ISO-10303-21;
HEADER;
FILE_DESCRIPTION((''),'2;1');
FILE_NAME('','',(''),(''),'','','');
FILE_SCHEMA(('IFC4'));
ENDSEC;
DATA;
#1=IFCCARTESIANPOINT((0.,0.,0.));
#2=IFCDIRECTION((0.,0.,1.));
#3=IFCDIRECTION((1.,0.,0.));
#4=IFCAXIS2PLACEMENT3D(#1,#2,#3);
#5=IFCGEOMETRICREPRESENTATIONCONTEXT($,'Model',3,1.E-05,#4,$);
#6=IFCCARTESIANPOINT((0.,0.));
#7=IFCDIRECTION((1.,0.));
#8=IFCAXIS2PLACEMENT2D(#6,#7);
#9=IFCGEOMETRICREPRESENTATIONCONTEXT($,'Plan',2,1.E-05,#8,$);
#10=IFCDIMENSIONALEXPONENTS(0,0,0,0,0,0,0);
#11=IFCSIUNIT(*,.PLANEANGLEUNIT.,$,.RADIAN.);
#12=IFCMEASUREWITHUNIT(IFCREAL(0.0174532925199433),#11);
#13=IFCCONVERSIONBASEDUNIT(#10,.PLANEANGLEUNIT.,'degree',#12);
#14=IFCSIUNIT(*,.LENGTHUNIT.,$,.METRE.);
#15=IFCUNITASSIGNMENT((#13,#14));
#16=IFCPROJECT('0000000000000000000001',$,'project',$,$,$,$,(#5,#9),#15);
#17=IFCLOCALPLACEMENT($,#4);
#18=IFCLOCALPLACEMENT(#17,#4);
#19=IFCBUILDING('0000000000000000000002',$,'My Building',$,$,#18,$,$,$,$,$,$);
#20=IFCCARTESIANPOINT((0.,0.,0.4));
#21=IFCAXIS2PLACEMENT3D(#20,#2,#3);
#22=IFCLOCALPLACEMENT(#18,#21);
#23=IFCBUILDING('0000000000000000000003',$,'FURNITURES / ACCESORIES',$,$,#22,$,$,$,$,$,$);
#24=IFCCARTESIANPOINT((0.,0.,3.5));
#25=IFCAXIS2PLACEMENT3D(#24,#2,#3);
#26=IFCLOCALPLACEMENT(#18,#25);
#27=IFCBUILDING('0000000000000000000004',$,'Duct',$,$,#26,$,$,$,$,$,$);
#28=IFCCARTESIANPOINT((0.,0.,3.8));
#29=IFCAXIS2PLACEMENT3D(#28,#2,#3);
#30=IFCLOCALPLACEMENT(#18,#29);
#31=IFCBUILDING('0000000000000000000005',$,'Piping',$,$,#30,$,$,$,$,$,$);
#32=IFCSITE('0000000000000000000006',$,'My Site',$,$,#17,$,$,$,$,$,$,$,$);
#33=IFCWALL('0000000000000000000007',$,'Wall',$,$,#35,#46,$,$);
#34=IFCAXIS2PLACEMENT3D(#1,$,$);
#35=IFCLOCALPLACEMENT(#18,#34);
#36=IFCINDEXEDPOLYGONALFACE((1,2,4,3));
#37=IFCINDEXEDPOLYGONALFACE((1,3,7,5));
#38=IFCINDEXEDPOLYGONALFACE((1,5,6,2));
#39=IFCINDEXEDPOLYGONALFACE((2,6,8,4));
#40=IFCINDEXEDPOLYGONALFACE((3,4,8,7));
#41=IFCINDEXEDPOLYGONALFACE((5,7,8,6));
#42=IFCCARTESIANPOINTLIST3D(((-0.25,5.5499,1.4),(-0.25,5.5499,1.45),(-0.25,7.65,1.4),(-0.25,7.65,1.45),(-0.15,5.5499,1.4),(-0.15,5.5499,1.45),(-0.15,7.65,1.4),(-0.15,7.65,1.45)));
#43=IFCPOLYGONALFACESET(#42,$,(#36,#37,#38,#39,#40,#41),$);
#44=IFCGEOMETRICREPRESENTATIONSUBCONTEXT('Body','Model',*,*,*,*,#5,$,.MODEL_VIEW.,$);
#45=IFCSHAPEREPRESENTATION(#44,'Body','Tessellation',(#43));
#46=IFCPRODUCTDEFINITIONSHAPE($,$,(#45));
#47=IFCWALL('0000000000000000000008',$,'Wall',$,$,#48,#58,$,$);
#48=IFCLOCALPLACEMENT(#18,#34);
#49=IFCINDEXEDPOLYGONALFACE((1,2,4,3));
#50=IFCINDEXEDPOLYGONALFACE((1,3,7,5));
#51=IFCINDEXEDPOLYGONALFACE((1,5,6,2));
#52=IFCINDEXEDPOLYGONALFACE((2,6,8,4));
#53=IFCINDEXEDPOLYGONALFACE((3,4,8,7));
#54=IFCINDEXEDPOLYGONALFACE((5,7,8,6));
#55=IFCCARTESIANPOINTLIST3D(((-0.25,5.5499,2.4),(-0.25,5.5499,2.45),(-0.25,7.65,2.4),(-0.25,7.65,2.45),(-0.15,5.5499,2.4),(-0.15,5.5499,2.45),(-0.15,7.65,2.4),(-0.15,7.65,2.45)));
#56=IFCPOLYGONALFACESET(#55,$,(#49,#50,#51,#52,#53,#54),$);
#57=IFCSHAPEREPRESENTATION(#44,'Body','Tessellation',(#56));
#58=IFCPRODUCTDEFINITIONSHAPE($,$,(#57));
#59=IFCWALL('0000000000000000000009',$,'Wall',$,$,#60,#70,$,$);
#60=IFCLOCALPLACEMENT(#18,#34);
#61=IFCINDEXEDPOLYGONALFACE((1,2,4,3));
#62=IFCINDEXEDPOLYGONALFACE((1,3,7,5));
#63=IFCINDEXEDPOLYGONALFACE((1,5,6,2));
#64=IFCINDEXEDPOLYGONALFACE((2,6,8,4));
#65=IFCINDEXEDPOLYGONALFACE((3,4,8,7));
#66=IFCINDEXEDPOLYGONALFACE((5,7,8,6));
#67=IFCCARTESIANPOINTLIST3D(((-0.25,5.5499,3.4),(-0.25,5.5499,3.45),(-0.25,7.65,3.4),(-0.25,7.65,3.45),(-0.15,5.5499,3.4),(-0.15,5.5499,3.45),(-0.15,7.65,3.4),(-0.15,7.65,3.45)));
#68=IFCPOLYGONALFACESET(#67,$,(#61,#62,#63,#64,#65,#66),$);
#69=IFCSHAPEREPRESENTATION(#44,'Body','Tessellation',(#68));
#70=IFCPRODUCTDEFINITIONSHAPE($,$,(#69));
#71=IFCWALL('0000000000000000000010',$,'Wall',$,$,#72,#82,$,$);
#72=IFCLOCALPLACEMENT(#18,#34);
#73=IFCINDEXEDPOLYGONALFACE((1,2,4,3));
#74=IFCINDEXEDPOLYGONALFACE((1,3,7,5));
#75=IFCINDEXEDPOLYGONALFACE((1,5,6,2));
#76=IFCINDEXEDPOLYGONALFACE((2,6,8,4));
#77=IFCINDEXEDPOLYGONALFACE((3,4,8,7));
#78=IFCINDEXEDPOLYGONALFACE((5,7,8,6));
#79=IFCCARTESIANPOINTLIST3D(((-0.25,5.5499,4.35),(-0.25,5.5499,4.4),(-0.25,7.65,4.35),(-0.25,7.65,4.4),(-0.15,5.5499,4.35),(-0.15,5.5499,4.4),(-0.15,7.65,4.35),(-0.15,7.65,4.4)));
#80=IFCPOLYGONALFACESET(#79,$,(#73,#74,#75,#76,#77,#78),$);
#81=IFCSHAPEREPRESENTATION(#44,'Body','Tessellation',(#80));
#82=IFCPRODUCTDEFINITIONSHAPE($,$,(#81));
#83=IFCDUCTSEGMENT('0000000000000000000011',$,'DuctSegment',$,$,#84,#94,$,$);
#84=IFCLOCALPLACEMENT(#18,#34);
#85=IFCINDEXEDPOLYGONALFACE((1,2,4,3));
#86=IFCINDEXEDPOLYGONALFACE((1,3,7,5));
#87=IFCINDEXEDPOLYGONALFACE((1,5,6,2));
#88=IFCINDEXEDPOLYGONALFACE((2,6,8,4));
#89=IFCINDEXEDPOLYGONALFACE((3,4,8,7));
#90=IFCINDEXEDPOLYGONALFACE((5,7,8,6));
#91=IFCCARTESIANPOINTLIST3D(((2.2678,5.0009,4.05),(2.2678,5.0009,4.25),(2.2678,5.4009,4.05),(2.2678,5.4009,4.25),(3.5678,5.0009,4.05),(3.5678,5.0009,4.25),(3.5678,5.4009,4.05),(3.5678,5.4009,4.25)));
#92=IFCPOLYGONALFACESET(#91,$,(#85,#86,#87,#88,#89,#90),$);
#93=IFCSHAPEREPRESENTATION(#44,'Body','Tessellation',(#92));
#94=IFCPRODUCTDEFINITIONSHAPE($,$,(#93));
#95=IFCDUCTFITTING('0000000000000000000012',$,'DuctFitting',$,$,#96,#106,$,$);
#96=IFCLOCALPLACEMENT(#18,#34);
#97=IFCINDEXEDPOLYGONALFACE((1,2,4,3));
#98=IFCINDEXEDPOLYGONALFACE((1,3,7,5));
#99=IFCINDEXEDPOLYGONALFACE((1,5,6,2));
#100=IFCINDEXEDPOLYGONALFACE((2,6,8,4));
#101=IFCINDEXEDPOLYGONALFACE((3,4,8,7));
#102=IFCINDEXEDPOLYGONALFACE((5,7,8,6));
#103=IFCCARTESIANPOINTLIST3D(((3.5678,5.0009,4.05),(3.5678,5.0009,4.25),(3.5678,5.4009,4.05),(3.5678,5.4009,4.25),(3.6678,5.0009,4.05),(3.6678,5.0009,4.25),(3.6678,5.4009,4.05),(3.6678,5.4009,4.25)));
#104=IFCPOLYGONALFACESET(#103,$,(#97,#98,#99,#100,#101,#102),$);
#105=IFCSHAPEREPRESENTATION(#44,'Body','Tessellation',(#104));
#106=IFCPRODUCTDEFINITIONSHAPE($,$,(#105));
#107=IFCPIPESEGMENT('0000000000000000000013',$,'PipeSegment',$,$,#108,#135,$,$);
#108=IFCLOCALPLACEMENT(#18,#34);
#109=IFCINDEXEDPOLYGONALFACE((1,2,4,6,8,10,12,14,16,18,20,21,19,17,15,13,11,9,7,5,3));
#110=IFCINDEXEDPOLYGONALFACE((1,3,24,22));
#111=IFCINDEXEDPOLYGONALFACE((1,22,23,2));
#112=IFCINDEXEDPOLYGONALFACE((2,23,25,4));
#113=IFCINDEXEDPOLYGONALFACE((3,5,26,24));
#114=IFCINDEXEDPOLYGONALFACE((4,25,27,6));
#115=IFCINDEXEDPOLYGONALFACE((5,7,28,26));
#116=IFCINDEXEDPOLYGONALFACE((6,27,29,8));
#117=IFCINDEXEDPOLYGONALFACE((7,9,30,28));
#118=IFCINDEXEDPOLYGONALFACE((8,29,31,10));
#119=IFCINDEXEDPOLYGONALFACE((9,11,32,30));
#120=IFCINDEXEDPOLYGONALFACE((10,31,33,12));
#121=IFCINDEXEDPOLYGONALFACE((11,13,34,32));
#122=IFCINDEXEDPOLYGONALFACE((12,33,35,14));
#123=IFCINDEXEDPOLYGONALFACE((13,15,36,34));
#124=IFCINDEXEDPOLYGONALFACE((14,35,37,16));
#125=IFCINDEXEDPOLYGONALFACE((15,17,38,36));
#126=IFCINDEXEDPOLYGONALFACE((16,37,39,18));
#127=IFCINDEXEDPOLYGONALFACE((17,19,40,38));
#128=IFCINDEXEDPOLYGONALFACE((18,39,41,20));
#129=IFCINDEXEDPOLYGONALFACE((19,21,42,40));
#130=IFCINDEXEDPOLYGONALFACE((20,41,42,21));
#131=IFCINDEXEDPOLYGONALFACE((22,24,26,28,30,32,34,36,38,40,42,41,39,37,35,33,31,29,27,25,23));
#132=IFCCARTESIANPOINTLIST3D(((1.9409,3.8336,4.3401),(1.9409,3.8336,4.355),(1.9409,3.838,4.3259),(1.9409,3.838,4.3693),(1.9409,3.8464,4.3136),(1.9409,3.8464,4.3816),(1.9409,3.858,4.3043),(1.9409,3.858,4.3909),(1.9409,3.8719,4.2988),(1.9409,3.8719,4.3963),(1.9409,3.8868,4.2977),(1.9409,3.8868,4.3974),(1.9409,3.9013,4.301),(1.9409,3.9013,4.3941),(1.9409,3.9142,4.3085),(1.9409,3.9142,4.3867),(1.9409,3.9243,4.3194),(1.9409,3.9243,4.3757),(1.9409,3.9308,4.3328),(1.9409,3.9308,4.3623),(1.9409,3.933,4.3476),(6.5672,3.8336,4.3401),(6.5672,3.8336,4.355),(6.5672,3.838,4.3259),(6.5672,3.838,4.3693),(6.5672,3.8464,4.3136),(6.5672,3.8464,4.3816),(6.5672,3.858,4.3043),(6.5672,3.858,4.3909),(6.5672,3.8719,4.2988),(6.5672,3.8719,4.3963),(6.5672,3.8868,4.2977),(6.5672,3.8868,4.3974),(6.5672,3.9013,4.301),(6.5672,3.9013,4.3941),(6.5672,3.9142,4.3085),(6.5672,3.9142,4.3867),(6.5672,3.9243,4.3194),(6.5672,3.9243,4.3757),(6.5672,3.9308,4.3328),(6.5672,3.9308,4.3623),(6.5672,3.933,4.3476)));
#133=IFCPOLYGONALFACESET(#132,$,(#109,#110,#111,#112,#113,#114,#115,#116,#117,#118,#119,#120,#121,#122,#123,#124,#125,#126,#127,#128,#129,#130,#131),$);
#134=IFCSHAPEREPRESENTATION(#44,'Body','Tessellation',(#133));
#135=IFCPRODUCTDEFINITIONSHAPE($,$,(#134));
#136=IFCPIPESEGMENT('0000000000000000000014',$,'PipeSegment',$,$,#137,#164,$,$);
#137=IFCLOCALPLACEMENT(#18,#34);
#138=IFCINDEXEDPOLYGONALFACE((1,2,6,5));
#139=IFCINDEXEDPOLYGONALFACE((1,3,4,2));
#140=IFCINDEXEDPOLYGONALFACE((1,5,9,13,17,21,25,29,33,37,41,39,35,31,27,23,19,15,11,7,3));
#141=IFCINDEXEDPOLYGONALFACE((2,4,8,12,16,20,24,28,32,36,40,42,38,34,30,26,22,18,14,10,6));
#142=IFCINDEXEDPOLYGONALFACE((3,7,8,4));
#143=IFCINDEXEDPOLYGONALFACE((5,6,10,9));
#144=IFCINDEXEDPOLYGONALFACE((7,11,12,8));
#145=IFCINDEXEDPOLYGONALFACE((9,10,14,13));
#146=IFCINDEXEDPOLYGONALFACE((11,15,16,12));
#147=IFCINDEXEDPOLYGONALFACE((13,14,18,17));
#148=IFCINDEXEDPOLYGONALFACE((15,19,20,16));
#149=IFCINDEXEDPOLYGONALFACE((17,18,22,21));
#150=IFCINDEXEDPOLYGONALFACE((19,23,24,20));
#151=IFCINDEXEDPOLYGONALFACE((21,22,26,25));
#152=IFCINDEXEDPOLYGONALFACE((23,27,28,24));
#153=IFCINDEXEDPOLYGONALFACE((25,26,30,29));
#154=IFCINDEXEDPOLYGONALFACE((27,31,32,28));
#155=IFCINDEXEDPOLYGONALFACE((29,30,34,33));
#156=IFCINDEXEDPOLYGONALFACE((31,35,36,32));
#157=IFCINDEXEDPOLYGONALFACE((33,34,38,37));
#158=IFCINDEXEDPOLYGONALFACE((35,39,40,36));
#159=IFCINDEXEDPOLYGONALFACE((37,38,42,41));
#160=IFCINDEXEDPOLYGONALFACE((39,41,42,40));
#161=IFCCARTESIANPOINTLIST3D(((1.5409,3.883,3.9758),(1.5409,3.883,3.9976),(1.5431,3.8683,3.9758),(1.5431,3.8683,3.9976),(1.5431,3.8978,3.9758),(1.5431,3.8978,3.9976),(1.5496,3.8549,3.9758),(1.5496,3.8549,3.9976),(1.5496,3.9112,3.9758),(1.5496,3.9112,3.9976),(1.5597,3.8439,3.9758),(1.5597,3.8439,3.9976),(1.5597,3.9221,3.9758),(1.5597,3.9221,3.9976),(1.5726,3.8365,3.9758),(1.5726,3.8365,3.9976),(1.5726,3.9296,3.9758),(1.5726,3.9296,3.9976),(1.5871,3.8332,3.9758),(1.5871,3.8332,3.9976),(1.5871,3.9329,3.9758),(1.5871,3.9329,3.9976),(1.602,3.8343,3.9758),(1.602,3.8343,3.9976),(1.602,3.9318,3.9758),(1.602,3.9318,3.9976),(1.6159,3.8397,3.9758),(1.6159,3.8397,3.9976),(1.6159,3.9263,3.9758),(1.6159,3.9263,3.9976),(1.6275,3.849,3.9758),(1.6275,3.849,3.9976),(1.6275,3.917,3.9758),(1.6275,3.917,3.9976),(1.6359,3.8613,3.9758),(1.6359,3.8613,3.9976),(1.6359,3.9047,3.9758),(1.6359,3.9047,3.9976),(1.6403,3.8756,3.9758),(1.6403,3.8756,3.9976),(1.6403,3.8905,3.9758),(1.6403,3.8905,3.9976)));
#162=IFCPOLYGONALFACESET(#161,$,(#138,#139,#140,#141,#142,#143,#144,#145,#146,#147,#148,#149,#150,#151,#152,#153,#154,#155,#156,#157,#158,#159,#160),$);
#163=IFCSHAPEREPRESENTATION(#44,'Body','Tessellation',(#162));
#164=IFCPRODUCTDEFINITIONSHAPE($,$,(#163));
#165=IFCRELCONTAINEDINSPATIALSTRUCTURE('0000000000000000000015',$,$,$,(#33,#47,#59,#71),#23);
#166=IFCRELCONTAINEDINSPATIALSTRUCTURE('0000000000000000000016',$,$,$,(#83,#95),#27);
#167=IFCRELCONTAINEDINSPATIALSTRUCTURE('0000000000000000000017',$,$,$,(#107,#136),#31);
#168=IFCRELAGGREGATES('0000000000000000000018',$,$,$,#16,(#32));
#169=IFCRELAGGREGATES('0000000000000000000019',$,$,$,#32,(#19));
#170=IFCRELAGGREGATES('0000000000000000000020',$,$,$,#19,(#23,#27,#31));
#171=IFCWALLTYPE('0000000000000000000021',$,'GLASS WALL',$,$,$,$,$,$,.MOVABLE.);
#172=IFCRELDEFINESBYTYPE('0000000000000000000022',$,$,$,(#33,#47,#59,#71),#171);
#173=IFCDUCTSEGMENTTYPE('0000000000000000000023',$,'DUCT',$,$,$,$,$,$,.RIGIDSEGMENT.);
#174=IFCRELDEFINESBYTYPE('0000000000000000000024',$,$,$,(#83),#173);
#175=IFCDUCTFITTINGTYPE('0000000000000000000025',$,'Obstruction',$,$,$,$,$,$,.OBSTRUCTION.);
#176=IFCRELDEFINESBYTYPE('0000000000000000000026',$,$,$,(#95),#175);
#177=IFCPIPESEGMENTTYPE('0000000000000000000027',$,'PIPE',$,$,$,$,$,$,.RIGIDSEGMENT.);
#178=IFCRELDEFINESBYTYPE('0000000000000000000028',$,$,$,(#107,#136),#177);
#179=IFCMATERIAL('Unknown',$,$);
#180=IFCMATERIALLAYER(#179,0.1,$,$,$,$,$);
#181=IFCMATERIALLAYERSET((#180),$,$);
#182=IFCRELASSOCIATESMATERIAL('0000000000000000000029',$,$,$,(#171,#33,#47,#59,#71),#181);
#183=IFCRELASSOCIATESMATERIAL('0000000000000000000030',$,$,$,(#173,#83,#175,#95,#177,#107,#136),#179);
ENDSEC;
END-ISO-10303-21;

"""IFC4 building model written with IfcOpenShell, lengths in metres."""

from ifc_helpers import new_model, entity, si_unit, converted_unit, frame, origin_with_axes, origin_2d_with_axis, place, context, subcontext, project, spatial, line, indexed_curve, rectangle, circle, outline, extrude, material, layer, layer_set, layer_usage, material_profile, profile_set, profile_usage, type_object, element, save


model = new_model("IFC4")

# Units and contexts
model_context = context("Model", 3, precision=1e-05, world=origin_with_axes())
plan_context = context("Plan", 2, precision=1e-05, world=origin_2d_with_axis())
body_context = subcontext(model_context, "Body", "Model", "MODEL_VIEW")
ifc_project = project(units=[converted_unit("PLANEANGLEUNIT", "degree", entity("IfcReal", 0.0174532925199433), si_unit("PLANEANGLEUNIT", "RADIAN"), dimensions=[0, 0, 0, 0, 0, 0, 0]), si_unit("LENGTHUNIT", "METRE")], contexts=[model_context, plan_context])

# Site, building
site_placement = place(None, origin_with_axes())
site = spatial("IfcSite", under=ifc_project, at=site_placement, Name="My Site")
building_1_placement = place(site_placement, origin_with_axes())
building_1 = spatial("IfcBuilding", under=site, at=building_1_placement, Name="My Building")

# Shared definitions
ifc_material = material(Name="Unknown")

# Shared definitions
building_2_placement = place(building_1_placement, frame((0.0, 0.0, 0.4), z_axis=(0.0, 0.0, 1.0), x_axis=(1.0, 0.0, 0.0)))
building_2 = spatial("IfcBuilding", under=building_1, at=building_2_placement, Name="FURNITURES / ACCESORIES")

# Walls
ifc_layer_1 = layer(ifc_material, 0.1)
ifc_layer_set_1 = layer_set([ifc_layer_1])
wall_type = type_object("IfcWallType", Name="GLASS WALL", PredefinedType="MOVABLE", material=ifc_layer_set_1)
ifc_layer_usage_1 = layer_usage(ifc_layer_set_1, "AXIS2", "POSITIVE", 0.0)
wall_1_placement = place(building_2_placement, frame((-0.15, 5.5499, 1.0), z_axis=(0.0, 0.0, 1.0), x_axis=(0.0, 1.0, 0.0)))
element("IfcWall", 1, at=wall_1_placement, inside=building_2, type_object=wall_type, material=ifc_layer_usage_1, Name="Wall", context=body_context, shape_type="SweptSolid", body=[
    extrude(outline(indexed_curve([(0.0, 0.0), (0.0, 0.1), (2.1001, 0.1), (2.1001, 0.0)], segments=[line(1, 2, 3, 4, 1)])), origin_with_axes(), (0.0, 0.0, 1.0), 0.05),
])
ifc_layer_usage_2 = layer_usage(ifc_layer_set_1, "AXIS2", "POSITIVE", 0.0)
wall_2_placement = place(building_2_placement, frame((-0.15, 5.5499, 2.0), z_axis=(0.0, 0.0, 1.0), x_axis=(0.0, 1.0, 0.0)))
element("IfcWall", 2, at=wall_2_placement, inside=building_2, type_object=wall_type, material=ifc_layer_usage_2, Name="Wall", context=body_context, shape_type="SweptSolid", body=[
    extrude(outline(indexed_curve([(0.0, 0.0), (0.0, 0.1), (2.1001, 0.1), (2.1001, 0.0)], segments=[line(1, 2, 3, 4, 1)])), origin_with_axes(), (0.0, 0.0, 1.0), 0.05),
])
ifc_layer_usage_3 = layer_usage(ifc_layer_set_1, "AXIS2", "POSITIVE", 0.0)
wall_3_placement = place(building_2_placement, frame((-0.15, 5.5499, 3.0), z_axis=(0.0, 0.0, 1.0), x_axis=(0.0, 1.0, 0.0)))
element("IfcWall", 3, at=wall_3_placement, inside=building_2, type_object=wall_type, material=ifc_layer_usage_3, Name="Wall", context=body_context, shape_type="SweptSolid", body=[
    extrude(outline(indexed_curve([(0.0, 0.0), (0.0, 0.1), (2.1001, 0.1), (2.1001, 0.0)], segments=[line(1, 2, 3, 4, 1)])), origin_with_axes(), (0.0, 0.0, 1.0), 0.05),
])
ifc_layer_usage_4 = layer_usage(ifc_layer_set_1, "AXIS2", "POSITIVE", 0.0)
wall_4_placement = place(building_2_placement, frame((-0.15, 5.5499, 3.95), z_axis=(0.0, 0.0, 1.0), x_axis=(0.0, 1.0, 0.0)))
element("IfcWall", 4, at=wall_4_placement, inside=building_2, type_object=wall_type, material=ifc_layer_usage_4, Name="Wall", context=body_context, shape_type="SweptSolid", body=[
    extrude(outline(indexed_curve([(0.0, 0.0), (0.0, 0.1), (2.1001, 0.1), (2.1001, 0.0)], segments=[line(1, 2, 3, 4, 1)])), origin_with_axes(), (0.0, 0.0, 1.0), 0.05),
])

# Shared definitions
building_3_placement = place(building_1_placement, frame((0.0, 0.0, 3.5), z_axis=(0.0, 0.0, 1.0), x_axis=(1.0, 0.0, 0.0)))
building_3 = spatial("IfcBuilding", under=building_1, at=building_3_placement, Name="Duct")

# Duct segment
ifc_material_profile_1 = material_profile(ifc_material, rectangle(XDim=0.4, YDim=0.2))
ifc_profile_set_1 = profile_set([ifc_material_profile_1])
ifc_profile_usage_1 = profile_usage(ifc_profile_set_1, cardinal=5)
duct_segment_type = type_object("IfcDuctSegmentType", Name="DUCT", PredefinedType="RIGIDSEGMENT", material=ifc_profile_set_1)
duct_segment_placement = place(building_3_placement, frame((3.5678, 5.2009, 0.65), z_axis=(-1.0, 0.0, 0.0), x_axis=(0.0, -1.0, 0.0)))
element("IfcDuctSegment", 5, at=duct_segment_placement, inside=building_3, type_object=duct_segment_type, material=ifc_profile_usage_1, Name="DuctSegment", context=body_context, shape_type="SweptSolid", body=[
    extrude(rectangle(XDim=0.4, YDim=0.2), origin_with_axes(), (0.0, 0.0, 1.0), 1.3),
])

# Duct fitting
ifc_material_profile_2 = material_profile(ifc_material, rectangle(XDim=0.4, YDim=0.2))
ifc_profile_set_2 = profile_set([ifc_material_profile_2])
ifc_profile_usage_2 = profile_usage(ifc_profile_set_2, cardinal=5)
duct_fitting_type = type_object("IfcDuctFittingType", Name="Obstruction", PredefinedType="OBSTRUCTION", material=ifc_profile_set_2)
duct_fitting_placement = place(building_3_placement, frame((3.6678, 5.2009, 0.65), z_axis=(-1.0, 0.0, 0.0), x_axis=(0.0, -1.0, 0.0)))
element("IfcDuctFitting", 6, at=duct_fitting_placement, inside=building_3, type_object=duct_fitting_type, material=ifc_profile_usage_2, Name="DuctFitting", context=body_context, shape_type="SweptSolid", body=[
    extrude(rectangle(XDim=0.4, YDim=0.2), origin_with_axes(), (0.0, 0.0, 1.0), 0.1),
])

# Shared definitions
building_4_placement = place(building_1_placement, frame((0.0, 0.0, 3.8), z_axis=(0.0, 0.0, 1.0), x_axis=(1.0, 0.0, 0.0)))
building_4 = spatial("IfcBuilding", under=building_1, at=building_4_placement, Name="Piping")

# Pipe segments
ifc_material_profile_3 = material_profile(ifc_material, circle(Radius=0.05))
ifc_profile_set_3 = profile_set([ifc_material_profile_3])
ifc_profile_usage_3 = profile_usage(ifc_profile_set_3, cardinal=5)
pipe_segment_type = type_object("IfcPipeSegmentType", Name="PIPE", PredefinedType="RIGIDSEGMENT", material=ifc_profile_set_3)
pipe_segment_1_placement = place(building_4_placement, frame((1.9409, 3.883, 0.5476), z_axis=(1.0, -0.000001, 0.000001), x_axis=(0.000001, 1.0, 0.0)))
element("IfcPipeSegment", 7, at=pipe_segment_1_placement, inside=building_4, type_object=pipe_segment_type, material=ifc_profile_usage_3, Name="PipeSegment", context=body_context, shape_type="SweptSolid", body=[
    extrude(circle(Radius=0.05), origin_with_axes(), (0.0, 0.0, 1.0), 4.6263),
])
ifc_profile_usage_4 = profile_usage(ifc_profile_set_3, cardinal=5)
pipe_segment_2_placement = place(building_4_placement, frame((1.5909, 3.883, 0.1976), z_axis=(0.0, 0.0, -1.0), x_axis=(-1.0, 0.0, 0.0)))
element("IfcPipeSegment", 8, at=pipe_segment_2_placement, inside=building_4, type_object=pipe_segment_type, material=ifc_profile_usage_4, Name="PipeSegment", context=body_context, shape_type="SweptSolid", body=[
    extrude(circle(Radius=0.05), origin_with_axes(), (0.0, 0.0, 1.0), 0.0218),
])

save(model, "model.ifc")
